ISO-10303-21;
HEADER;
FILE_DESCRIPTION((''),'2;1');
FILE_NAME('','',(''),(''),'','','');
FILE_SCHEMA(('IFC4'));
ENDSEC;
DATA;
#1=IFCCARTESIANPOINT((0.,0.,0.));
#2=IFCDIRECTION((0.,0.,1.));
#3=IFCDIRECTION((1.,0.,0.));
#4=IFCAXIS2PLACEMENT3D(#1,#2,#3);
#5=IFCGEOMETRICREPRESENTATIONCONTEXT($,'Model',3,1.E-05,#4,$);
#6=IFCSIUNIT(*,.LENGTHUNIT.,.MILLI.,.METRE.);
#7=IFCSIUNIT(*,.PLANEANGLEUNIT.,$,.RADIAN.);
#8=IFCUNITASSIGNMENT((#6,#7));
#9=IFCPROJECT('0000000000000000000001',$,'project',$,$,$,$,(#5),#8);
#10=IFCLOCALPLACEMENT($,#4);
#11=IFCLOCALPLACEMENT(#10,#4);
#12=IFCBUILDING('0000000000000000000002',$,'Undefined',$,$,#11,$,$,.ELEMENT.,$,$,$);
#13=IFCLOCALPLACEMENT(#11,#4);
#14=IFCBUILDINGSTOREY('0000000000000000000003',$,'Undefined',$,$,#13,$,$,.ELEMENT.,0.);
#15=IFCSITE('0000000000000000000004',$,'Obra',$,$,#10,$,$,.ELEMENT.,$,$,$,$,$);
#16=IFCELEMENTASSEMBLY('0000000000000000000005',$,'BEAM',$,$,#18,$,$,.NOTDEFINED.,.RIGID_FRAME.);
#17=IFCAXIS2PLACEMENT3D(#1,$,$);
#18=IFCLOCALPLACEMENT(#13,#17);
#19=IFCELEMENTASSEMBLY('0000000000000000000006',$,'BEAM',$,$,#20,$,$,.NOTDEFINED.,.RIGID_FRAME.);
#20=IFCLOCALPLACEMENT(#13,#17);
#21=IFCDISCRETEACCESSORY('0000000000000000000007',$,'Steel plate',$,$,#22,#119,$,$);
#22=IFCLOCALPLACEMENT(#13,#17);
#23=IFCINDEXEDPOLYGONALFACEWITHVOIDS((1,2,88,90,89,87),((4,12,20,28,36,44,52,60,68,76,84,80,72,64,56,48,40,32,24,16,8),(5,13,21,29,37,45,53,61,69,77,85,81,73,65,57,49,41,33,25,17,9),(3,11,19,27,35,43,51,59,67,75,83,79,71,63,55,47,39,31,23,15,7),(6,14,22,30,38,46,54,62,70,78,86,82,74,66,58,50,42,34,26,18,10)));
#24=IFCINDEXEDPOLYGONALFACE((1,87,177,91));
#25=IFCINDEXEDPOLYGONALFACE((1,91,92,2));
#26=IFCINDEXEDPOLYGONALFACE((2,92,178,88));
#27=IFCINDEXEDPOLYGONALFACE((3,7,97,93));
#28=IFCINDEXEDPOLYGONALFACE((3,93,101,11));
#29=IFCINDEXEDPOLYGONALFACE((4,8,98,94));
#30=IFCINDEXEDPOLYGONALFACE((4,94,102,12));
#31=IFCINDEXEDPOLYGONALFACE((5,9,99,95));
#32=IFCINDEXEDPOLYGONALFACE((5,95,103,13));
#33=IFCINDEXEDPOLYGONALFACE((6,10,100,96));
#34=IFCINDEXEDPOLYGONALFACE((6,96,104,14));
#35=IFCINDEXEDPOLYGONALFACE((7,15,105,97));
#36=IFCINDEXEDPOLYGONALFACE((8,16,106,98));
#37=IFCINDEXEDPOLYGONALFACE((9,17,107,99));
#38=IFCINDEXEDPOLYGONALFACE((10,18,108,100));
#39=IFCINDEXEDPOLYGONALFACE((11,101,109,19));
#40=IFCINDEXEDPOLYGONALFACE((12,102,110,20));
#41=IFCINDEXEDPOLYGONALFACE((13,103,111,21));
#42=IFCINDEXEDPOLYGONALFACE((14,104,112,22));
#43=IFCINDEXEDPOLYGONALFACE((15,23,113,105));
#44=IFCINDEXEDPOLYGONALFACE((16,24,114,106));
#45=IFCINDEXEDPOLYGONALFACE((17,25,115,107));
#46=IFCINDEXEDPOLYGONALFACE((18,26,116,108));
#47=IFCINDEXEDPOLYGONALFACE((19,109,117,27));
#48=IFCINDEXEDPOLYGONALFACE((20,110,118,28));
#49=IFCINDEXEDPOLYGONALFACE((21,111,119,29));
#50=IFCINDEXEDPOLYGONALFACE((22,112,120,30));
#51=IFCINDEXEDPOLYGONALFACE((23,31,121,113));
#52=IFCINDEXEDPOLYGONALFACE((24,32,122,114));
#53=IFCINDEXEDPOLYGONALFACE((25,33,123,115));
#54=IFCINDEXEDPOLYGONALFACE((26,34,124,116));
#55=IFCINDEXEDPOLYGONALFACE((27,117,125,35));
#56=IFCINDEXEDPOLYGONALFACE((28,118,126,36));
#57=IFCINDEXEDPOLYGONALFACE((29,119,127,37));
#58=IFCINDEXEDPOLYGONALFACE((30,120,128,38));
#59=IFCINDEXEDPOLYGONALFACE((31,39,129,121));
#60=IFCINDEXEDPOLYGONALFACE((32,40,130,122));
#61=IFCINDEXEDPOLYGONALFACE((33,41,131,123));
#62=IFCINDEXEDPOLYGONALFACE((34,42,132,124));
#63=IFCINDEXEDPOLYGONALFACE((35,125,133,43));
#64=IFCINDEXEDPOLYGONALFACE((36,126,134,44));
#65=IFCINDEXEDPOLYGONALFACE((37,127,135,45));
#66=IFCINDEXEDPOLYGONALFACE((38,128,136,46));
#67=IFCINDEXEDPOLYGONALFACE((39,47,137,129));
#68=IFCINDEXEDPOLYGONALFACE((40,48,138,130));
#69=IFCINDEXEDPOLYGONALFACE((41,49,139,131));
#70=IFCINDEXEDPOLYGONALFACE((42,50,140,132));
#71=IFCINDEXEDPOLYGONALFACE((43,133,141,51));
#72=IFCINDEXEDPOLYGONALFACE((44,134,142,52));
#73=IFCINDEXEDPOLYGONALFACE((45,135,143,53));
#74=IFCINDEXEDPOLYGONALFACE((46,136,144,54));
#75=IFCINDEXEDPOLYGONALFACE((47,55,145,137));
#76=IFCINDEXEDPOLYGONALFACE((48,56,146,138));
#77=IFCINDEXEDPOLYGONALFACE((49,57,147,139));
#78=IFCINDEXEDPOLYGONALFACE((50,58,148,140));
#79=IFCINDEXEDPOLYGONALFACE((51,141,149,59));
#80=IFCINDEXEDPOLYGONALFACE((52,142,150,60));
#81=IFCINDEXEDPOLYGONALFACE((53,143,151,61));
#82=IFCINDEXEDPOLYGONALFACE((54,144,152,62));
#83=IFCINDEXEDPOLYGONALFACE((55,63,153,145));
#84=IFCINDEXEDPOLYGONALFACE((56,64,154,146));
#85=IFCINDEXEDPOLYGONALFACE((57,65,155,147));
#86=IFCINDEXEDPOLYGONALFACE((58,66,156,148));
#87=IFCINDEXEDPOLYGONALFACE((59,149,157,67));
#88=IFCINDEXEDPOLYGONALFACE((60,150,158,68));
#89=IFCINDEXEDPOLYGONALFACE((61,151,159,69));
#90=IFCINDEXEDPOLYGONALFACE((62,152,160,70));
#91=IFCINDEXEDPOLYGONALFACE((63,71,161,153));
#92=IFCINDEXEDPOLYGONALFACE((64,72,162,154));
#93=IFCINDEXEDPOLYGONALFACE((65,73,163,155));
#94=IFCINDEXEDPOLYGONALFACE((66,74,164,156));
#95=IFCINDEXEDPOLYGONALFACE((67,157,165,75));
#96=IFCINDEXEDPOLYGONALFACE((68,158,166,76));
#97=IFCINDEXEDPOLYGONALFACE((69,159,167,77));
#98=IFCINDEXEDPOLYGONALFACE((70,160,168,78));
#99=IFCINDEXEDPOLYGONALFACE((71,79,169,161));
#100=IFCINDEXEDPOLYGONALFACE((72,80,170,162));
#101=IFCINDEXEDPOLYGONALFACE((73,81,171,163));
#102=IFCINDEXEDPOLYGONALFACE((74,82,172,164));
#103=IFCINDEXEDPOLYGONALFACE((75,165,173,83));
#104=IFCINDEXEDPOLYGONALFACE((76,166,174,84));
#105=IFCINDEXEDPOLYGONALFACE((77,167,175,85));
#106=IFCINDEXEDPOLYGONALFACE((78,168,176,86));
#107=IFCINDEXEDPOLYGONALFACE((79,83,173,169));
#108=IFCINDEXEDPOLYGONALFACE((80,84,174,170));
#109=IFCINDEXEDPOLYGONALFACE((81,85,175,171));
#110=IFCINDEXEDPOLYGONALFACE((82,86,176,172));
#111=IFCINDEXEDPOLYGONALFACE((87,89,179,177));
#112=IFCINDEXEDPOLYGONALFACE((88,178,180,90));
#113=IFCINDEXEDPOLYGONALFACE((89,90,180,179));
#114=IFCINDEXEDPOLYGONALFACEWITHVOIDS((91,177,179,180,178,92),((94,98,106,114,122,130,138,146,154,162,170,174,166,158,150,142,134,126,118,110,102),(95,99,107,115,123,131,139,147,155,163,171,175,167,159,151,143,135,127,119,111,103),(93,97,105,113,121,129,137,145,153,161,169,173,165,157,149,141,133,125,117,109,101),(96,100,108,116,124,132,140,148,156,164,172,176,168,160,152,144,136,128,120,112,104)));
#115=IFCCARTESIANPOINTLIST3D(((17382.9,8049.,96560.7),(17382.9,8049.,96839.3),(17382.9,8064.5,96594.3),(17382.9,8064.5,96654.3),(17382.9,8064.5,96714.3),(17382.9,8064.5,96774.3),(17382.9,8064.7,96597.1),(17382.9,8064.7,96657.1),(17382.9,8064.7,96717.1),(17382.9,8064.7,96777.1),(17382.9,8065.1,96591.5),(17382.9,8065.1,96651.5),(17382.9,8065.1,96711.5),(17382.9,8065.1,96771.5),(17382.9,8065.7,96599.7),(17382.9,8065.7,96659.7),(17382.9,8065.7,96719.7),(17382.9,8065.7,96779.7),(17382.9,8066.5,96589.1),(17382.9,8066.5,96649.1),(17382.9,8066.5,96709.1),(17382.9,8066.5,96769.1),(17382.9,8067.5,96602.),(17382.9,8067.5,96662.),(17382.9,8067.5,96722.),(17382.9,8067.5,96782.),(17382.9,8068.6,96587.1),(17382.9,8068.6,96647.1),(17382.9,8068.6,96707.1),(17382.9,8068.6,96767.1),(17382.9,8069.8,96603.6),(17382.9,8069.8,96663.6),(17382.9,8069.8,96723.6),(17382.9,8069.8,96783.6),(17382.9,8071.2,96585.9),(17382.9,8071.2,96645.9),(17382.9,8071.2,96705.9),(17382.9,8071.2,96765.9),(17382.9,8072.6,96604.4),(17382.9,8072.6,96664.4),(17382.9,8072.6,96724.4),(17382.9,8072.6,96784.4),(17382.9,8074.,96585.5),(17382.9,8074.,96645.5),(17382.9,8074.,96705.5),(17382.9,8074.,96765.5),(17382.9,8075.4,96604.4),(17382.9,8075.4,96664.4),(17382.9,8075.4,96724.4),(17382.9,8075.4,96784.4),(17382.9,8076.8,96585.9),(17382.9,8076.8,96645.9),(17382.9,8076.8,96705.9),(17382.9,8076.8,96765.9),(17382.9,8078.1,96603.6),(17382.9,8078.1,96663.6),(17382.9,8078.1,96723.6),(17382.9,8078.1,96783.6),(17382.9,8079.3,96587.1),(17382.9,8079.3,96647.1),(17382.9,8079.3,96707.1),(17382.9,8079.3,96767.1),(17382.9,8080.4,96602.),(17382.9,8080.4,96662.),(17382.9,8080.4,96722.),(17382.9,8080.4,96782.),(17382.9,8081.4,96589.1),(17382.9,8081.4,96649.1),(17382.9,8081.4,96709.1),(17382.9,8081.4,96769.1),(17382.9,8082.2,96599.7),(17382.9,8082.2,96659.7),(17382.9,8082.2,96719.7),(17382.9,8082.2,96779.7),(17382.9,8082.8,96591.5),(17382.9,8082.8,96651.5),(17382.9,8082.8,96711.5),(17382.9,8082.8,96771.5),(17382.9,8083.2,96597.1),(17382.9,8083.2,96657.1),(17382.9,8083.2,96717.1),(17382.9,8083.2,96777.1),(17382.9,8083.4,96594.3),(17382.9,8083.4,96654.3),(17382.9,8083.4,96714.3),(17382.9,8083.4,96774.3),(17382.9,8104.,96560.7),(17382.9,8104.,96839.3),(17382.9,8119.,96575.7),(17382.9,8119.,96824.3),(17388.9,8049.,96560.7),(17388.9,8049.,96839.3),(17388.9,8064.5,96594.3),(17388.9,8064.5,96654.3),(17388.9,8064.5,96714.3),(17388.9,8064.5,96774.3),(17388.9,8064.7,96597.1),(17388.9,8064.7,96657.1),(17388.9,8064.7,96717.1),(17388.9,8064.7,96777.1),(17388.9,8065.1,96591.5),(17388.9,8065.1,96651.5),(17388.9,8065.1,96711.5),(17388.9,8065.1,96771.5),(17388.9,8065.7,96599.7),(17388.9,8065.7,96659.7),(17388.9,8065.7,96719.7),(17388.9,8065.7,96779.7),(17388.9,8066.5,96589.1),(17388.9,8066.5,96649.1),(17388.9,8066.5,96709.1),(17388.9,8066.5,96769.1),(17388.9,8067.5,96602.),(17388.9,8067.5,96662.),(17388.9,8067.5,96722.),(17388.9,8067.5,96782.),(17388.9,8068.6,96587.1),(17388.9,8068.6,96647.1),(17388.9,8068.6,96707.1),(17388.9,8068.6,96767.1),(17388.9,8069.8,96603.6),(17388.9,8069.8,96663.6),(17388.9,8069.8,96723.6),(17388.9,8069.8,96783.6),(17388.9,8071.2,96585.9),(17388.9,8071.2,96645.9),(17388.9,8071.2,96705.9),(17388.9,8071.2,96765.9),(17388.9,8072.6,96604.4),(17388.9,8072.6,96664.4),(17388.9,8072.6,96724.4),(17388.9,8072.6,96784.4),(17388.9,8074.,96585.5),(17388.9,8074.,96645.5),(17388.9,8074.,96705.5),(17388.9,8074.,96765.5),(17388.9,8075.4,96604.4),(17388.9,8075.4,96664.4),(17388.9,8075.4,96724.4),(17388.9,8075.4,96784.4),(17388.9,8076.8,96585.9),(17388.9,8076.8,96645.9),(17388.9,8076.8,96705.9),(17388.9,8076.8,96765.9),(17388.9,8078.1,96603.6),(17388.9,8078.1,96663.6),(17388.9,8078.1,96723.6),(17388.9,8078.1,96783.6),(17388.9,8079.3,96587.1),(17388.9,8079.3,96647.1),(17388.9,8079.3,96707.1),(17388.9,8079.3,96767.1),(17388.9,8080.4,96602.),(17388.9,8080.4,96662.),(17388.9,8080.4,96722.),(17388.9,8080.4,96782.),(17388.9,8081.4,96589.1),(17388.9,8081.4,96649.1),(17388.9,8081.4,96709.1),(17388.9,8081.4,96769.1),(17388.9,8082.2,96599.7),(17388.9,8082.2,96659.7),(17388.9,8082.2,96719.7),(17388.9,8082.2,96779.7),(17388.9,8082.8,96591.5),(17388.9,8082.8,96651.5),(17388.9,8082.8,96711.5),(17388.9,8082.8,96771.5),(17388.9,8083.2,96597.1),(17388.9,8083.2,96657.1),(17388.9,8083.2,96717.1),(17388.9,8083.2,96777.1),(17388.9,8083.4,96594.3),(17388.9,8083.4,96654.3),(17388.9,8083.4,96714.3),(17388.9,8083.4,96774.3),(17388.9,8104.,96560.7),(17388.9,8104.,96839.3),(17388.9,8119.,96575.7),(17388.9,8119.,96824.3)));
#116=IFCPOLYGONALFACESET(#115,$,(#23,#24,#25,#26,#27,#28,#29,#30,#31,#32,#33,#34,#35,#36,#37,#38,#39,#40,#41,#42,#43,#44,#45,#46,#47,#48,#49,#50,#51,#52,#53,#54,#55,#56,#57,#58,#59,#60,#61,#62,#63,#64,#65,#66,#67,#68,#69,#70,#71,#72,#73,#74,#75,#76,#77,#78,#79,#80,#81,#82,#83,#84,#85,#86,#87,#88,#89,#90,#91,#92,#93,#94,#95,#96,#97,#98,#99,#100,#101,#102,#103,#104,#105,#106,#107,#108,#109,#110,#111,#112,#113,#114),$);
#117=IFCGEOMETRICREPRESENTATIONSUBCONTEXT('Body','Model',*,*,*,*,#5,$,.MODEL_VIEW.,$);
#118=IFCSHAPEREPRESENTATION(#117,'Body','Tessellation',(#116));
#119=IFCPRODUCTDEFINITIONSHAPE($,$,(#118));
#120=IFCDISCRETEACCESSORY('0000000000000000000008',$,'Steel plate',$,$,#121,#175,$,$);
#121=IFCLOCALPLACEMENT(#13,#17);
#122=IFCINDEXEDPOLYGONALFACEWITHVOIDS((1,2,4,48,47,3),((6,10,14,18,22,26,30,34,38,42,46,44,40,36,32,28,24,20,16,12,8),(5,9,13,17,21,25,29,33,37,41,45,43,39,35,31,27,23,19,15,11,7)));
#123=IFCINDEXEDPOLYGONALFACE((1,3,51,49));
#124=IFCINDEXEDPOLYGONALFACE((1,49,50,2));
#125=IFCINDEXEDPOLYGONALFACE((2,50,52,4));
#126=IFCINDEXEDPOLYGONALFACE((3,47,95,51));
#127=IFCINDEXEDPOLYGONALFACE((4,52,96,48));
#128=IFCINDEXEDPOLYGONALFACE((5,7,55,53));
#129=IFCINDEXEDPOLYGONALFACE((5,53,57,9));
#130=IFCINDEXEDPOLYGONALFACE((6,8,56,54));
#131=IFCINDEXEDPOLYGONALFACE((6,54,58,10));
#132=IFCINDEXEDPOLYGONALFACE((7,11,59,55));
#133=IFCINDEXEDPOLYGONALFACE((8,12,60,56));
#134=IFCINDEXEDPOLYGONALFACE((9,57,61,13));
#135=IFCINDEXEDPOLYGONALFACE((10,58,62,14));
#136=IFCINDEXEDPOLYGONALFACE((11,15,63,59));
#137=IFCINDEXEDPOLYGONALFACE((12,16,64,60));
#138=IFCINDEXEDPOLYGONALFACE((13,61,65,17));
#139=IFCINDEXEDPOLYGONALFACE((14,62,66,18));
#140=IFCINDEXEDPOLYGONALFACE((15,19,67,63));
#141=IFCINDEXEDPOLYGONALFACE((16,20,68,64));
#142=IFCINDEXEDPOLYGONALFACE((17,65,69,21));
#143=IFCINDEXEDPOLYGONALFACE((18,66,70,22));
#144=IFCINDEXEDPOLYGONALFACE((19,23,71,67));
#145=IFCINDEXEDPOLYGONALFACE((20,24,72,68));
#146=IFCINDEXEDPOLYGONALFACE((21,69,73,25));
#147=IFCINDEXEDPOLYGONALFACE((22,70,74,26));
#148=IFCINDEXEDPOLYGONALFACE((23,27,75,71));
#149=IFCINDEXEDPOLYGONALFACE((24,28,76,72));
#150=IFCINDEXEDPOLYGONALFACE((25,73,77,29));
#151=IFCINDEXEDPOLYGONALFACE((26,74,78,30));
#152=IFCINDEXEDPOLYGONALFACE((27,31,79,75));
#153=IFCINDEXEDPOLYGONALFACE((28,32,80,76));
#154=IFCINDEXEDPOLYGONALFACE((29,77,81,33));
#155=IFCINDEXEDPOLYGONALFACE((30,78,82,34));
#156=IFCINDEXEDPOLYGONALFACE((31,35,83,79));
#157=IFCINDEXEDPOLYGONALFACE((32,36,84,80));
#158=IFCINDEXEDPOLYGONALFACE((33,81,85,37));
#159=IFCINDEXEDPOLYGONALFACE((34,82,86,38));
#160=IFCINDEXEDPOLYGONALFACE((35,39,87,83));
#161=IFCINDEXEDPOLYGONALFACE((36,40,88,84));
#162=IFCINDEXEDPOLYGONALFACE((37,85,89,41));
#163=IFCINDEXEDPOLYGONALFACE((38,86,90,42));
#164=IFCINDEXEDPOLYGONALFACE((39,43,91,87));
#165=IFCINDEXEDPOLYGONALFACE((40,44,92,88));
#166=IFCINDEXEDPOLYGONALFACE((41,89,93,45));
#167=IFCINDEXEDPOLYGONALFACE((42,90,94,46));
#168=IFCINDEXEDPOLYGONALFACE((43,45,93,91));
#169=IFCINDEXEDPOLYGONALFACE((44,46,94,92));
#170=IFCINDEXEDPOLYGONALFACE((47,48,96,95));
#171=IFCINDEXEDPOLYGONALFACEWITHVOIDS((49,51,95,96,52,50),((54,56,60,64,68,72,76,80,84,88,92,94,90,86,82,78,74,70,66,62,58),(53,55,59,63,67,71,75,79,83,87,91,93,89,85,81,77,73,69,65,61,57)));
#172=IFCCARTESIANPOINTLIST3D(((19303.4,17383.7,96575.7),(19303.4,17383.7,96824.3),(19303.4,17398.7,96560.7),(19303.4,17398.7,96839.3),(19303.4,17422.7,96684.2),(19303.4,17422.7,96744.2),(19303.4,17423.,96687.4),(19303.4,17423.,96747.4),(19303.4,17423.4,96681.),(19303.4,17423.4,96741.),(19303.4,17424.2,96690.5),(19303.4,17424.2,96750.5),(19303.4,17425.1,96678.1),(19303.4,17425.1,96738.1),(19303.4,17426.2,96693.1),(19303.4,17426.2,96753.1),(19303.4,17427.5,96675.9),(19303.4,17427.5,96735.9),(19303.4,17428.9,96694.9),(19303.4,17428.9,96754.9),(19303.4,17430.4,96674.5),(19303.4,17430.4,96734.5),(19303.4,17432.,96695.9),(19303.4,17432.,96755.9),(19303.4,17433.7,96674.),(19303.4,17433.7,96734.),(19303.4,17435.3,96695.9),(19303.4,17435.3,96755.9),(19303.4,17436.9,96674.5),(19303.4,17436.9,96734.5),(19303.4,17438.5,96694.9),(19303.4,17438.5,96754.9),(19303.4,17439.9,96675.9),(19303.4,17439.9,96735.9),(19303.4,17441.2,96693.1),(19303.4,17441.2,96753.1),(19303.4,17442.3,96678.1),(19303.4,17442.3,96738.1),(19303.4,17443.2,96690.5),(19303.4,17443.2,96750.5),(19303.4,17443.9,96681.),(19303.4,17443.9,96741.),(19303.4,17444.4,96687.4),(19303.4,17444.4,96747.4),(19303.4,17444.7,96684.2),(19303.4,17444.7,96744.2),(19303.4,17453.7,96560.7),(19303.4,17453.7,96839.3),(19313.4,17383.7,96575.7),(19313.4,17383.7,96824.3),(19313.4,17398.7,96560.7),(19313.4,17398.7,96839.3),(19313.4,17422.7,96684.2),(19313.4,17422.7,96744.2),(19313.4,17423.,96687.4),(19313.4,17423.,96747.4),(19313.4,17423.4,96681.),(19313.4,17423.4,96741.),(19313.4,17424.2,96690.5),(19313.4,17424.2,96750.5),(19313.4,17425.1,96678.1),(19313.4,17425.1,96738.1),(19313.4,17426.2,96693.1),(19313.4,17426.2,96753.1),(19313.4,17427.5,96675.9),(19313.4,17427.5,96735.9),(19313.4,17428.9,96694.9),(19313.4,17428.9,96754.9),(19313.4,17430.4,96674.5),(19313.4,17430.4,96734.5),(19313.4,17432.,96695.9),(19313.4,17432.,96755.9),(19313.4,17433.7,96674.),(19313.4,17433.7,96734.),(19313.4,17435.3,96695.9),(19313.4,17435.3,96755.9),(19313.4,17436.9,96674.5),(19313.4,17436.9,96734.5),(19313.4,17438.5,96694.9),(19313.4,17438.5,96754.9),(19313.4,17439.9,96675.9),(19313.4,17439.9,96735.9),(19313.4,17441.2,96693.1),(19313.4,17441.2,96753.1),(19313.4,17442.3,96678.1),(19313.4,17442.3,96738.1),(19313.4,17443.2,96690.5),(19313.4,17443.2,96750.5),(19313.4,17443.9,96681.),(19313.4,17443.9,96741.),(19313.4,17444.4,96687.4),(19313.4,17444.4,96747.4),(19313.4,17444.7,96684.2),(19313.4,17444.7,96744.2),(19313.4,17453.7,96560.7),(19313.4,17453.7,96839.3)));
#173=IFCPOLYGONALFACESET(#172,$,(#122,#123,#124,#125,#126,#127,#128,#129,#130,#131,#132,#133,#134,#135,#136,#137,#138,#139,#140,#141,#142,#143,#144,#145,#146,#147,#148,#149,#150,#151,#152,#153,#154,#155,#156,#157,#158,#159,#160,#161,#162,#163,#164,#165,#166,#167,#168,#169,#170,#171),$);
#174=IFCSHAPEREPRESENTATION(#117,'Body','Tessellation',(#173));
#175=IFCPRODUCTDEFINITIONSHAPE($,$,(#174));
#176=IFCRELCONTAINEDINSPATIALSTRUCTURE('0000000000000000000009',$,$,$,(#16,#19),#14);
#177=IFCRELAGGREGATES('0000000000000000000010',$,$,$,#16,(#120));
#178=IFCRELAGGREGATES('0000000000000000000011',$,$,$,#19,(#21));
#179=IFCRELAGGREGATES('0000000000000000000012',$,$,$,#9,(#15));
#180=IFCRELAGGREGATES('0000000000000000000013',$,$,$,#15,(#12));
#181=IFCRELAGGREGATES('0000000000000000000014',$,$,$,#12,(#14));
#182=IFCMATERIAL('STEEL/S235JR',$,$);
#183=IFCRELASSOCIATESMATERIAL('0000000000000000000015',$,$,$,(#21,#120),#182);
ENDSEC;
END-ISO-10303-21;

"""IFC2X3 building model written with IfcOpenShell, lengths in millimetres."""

from ifc_helpers import new_model, si_unit, frame, origin_with_axes, origin_2d_with_axis, place, context, subcontext, project, spatial, polyline, circle, outline, extrude, source, transform, mapped, material, element, aggregate, save


model = new_model("IFC2X3")

# Units and contexts
model_context = context("Model", 3, precision=1e-05, world=origin_with_axes())
body_context = subcontext(model_context, "Body", "Model", "MODEL_VIEW")
ifc_project = project(units=[si_unit("LENGTHUNIT", "METRE", prefix="MILLI"), si_unit("PLANEANGLEUNIT", "RADIAN")], contexts=[model_context])

# Site, building, storey
site_placement = place(None, origin_with_axes())
site = spatial("IfcSite", under=ifc_project, at=site_placement, Name="Obra", CompositionType="ELEMENT")
building_placement = place(site_placement, origin_with_axes())
building = spatial("IfcBuilding", under=site, at=building_placement, Name="Undefined", CompositionType="ELEMENT")
storey_placement = place(building_placement, origin_with_axes())
storey = spatial("IfcBuildingStorey", under=building, at=storey_placement, Name="Undefined", CompositionType="ELEMENT", Elevation=0.0)

# Element assemblies, discrete accessory, opening
assembly_1_placement = place(storey_placement, origin_with_axes())
assembly_1 = element("IfcElementAssembly", 1, at=assembly_1_placement, inside=storey, Name="BEAM", AssemblyPlace="NOTDEFINED", PredefinedType="RIGID_FRAME")
ifc_material_1 = material(Name="STEEL/S235JR")
shared_shape_1 = source(origin_with_axes(), body_context, "Body", "SweptSolid", [
    extrude(circle(Radius=9.5, at=origin_2d_with_axis()), frame((0.0, -9.8, 0.0), z_axis=(0.0, 1.0, 0.0), x_axis=(1.0, 0.0, 0.0)), (0.0, 0.0, 1.0), 6.2),
])
assembly_2_placement = place(storey_placement, origin_with_axes())
assembly_2 = element("IfcElementAssembly", 2, at=assembly_2_placement, inside=storey, Name="BEAM", AssemblyPlace="NOTDEFINED", PredefinedType="RIGID_FRAME")
discrete_accessory_1_placement = place(assembly_2_placement, frame((17385.9, 8049.0, 96560.7), z_axis=(1.0, 0.0, 0.0), x_axis=(0.0, 1.0, 0.0)))
discrete_accessory_1 = element("IfcDiscreteAccessory", 3, at=discrete_accessory_1_placement, material=ifc_material_1, Name="Steel plate", context=body_context, shape_type="SweptSolid", body=[
    extrude(outline(polyline([(0.0, 0.0), (55.0, 0.0), (70.0, 15.0), (70.0, 263.6), (55.0, 278.6), (0.0, 278.6), (0.0, 0.0)])), frame((0.0, 0.0, -3.0), z_axis=(0.0, 0.0, 1.0), x_axis=(1.0, 0.0, 0.0)), (0.0, 0.0, 1.0), 6.0),
])
opening_1_placement = place(assembly_2_placement, frame((17392.7, 8109.0, 96850.0), z_axis=(0.0, -1.0, 0.0), x_axis=(0.0, 0.0, -1.0)))
element("IfcOpeningElement", 4, at=opening_1_placement, cuts=discrete_accessory_1, ObjectType="Opening", context=body_context, shape_type="MappedRepresentation", body=[
    mapped(shared_shape_1, transform((75.0, 0.0, 35.0))),
    mapped(shared_shape_1, transform((135.0, 0.0, 35.0))),
    mapped(shared_shape_1, transform((195.0, 0.0, 35.0))),
    mapped(shared_shape_1, transform((255.0, 0.0, 35.0))),
])

# Discrete accessory, opening
discrete_accessory_2_placement = place(assembly_1_placement, frame((19308.4, 17453.7, 96560.7), z_axis=(-1.0, 0.0, 0.0), x_axis=(0.0, -1.0, 0.0)))
discrete_accessory_2 = element("IfcDiscreteAccessory", 5, at=discrete_accessory_2_placement, material=ifc_material_1, Name="Steel plate", context=body_context, shape_type="SweptSolid", body=[
    extrude(outline(polyline([(0.0, 0.0), (55.0, 0.0), (70.0, 15.0), (70.0, 263.6), (55.0, 278.6), (0.0, 278.6), (0.0, 0.0)])), frame((0.0, 0.0, -5.0), z_axis=(0.0, 0.0, 1.0), x_axis=(1.0, 0.0, 0.0)), (0.0, 0.0, 1.0), 10.0),
])
shared_shape_2 = source(origin_with_axes(), body_context, "Body", "SweptSolid", [
    extrude(circle(Radius=11.0, at=origin_2d_with_axis()), frame((0.0, -13.4, 0.0), z_axis=(0.0, 1.0, 0.0), x_axis=(1.0, 0.0, 0.0)), (0.0, 0.0, 1.0), 10.2),
])
opening_2_placement = place(assembly_1_placement, frame((19300.1, 17393.7, 96850.0), z_axis=(0.0, 1.0, 0.0), x_axis=(0.0, 0.0, -1.0)))
element("IfcOpeningElement", 6, at=opening_2_placement, cuts=discrete_accessory_2, ObjectType="Opening", context=body_context, shape_type="MappedRepresentation", body=[
    mapped(shared_shape_2, transform((105.0, 0.0, 40.0))),
    mapped(shared_shape_2, transform((165.0, 0.0, 40.0))),
])
aggregate(assembly_1, [discrete_accessory_2])
aggregate(assembly_2, [discrete_accessory_1])

save(model, "model.ifc")
